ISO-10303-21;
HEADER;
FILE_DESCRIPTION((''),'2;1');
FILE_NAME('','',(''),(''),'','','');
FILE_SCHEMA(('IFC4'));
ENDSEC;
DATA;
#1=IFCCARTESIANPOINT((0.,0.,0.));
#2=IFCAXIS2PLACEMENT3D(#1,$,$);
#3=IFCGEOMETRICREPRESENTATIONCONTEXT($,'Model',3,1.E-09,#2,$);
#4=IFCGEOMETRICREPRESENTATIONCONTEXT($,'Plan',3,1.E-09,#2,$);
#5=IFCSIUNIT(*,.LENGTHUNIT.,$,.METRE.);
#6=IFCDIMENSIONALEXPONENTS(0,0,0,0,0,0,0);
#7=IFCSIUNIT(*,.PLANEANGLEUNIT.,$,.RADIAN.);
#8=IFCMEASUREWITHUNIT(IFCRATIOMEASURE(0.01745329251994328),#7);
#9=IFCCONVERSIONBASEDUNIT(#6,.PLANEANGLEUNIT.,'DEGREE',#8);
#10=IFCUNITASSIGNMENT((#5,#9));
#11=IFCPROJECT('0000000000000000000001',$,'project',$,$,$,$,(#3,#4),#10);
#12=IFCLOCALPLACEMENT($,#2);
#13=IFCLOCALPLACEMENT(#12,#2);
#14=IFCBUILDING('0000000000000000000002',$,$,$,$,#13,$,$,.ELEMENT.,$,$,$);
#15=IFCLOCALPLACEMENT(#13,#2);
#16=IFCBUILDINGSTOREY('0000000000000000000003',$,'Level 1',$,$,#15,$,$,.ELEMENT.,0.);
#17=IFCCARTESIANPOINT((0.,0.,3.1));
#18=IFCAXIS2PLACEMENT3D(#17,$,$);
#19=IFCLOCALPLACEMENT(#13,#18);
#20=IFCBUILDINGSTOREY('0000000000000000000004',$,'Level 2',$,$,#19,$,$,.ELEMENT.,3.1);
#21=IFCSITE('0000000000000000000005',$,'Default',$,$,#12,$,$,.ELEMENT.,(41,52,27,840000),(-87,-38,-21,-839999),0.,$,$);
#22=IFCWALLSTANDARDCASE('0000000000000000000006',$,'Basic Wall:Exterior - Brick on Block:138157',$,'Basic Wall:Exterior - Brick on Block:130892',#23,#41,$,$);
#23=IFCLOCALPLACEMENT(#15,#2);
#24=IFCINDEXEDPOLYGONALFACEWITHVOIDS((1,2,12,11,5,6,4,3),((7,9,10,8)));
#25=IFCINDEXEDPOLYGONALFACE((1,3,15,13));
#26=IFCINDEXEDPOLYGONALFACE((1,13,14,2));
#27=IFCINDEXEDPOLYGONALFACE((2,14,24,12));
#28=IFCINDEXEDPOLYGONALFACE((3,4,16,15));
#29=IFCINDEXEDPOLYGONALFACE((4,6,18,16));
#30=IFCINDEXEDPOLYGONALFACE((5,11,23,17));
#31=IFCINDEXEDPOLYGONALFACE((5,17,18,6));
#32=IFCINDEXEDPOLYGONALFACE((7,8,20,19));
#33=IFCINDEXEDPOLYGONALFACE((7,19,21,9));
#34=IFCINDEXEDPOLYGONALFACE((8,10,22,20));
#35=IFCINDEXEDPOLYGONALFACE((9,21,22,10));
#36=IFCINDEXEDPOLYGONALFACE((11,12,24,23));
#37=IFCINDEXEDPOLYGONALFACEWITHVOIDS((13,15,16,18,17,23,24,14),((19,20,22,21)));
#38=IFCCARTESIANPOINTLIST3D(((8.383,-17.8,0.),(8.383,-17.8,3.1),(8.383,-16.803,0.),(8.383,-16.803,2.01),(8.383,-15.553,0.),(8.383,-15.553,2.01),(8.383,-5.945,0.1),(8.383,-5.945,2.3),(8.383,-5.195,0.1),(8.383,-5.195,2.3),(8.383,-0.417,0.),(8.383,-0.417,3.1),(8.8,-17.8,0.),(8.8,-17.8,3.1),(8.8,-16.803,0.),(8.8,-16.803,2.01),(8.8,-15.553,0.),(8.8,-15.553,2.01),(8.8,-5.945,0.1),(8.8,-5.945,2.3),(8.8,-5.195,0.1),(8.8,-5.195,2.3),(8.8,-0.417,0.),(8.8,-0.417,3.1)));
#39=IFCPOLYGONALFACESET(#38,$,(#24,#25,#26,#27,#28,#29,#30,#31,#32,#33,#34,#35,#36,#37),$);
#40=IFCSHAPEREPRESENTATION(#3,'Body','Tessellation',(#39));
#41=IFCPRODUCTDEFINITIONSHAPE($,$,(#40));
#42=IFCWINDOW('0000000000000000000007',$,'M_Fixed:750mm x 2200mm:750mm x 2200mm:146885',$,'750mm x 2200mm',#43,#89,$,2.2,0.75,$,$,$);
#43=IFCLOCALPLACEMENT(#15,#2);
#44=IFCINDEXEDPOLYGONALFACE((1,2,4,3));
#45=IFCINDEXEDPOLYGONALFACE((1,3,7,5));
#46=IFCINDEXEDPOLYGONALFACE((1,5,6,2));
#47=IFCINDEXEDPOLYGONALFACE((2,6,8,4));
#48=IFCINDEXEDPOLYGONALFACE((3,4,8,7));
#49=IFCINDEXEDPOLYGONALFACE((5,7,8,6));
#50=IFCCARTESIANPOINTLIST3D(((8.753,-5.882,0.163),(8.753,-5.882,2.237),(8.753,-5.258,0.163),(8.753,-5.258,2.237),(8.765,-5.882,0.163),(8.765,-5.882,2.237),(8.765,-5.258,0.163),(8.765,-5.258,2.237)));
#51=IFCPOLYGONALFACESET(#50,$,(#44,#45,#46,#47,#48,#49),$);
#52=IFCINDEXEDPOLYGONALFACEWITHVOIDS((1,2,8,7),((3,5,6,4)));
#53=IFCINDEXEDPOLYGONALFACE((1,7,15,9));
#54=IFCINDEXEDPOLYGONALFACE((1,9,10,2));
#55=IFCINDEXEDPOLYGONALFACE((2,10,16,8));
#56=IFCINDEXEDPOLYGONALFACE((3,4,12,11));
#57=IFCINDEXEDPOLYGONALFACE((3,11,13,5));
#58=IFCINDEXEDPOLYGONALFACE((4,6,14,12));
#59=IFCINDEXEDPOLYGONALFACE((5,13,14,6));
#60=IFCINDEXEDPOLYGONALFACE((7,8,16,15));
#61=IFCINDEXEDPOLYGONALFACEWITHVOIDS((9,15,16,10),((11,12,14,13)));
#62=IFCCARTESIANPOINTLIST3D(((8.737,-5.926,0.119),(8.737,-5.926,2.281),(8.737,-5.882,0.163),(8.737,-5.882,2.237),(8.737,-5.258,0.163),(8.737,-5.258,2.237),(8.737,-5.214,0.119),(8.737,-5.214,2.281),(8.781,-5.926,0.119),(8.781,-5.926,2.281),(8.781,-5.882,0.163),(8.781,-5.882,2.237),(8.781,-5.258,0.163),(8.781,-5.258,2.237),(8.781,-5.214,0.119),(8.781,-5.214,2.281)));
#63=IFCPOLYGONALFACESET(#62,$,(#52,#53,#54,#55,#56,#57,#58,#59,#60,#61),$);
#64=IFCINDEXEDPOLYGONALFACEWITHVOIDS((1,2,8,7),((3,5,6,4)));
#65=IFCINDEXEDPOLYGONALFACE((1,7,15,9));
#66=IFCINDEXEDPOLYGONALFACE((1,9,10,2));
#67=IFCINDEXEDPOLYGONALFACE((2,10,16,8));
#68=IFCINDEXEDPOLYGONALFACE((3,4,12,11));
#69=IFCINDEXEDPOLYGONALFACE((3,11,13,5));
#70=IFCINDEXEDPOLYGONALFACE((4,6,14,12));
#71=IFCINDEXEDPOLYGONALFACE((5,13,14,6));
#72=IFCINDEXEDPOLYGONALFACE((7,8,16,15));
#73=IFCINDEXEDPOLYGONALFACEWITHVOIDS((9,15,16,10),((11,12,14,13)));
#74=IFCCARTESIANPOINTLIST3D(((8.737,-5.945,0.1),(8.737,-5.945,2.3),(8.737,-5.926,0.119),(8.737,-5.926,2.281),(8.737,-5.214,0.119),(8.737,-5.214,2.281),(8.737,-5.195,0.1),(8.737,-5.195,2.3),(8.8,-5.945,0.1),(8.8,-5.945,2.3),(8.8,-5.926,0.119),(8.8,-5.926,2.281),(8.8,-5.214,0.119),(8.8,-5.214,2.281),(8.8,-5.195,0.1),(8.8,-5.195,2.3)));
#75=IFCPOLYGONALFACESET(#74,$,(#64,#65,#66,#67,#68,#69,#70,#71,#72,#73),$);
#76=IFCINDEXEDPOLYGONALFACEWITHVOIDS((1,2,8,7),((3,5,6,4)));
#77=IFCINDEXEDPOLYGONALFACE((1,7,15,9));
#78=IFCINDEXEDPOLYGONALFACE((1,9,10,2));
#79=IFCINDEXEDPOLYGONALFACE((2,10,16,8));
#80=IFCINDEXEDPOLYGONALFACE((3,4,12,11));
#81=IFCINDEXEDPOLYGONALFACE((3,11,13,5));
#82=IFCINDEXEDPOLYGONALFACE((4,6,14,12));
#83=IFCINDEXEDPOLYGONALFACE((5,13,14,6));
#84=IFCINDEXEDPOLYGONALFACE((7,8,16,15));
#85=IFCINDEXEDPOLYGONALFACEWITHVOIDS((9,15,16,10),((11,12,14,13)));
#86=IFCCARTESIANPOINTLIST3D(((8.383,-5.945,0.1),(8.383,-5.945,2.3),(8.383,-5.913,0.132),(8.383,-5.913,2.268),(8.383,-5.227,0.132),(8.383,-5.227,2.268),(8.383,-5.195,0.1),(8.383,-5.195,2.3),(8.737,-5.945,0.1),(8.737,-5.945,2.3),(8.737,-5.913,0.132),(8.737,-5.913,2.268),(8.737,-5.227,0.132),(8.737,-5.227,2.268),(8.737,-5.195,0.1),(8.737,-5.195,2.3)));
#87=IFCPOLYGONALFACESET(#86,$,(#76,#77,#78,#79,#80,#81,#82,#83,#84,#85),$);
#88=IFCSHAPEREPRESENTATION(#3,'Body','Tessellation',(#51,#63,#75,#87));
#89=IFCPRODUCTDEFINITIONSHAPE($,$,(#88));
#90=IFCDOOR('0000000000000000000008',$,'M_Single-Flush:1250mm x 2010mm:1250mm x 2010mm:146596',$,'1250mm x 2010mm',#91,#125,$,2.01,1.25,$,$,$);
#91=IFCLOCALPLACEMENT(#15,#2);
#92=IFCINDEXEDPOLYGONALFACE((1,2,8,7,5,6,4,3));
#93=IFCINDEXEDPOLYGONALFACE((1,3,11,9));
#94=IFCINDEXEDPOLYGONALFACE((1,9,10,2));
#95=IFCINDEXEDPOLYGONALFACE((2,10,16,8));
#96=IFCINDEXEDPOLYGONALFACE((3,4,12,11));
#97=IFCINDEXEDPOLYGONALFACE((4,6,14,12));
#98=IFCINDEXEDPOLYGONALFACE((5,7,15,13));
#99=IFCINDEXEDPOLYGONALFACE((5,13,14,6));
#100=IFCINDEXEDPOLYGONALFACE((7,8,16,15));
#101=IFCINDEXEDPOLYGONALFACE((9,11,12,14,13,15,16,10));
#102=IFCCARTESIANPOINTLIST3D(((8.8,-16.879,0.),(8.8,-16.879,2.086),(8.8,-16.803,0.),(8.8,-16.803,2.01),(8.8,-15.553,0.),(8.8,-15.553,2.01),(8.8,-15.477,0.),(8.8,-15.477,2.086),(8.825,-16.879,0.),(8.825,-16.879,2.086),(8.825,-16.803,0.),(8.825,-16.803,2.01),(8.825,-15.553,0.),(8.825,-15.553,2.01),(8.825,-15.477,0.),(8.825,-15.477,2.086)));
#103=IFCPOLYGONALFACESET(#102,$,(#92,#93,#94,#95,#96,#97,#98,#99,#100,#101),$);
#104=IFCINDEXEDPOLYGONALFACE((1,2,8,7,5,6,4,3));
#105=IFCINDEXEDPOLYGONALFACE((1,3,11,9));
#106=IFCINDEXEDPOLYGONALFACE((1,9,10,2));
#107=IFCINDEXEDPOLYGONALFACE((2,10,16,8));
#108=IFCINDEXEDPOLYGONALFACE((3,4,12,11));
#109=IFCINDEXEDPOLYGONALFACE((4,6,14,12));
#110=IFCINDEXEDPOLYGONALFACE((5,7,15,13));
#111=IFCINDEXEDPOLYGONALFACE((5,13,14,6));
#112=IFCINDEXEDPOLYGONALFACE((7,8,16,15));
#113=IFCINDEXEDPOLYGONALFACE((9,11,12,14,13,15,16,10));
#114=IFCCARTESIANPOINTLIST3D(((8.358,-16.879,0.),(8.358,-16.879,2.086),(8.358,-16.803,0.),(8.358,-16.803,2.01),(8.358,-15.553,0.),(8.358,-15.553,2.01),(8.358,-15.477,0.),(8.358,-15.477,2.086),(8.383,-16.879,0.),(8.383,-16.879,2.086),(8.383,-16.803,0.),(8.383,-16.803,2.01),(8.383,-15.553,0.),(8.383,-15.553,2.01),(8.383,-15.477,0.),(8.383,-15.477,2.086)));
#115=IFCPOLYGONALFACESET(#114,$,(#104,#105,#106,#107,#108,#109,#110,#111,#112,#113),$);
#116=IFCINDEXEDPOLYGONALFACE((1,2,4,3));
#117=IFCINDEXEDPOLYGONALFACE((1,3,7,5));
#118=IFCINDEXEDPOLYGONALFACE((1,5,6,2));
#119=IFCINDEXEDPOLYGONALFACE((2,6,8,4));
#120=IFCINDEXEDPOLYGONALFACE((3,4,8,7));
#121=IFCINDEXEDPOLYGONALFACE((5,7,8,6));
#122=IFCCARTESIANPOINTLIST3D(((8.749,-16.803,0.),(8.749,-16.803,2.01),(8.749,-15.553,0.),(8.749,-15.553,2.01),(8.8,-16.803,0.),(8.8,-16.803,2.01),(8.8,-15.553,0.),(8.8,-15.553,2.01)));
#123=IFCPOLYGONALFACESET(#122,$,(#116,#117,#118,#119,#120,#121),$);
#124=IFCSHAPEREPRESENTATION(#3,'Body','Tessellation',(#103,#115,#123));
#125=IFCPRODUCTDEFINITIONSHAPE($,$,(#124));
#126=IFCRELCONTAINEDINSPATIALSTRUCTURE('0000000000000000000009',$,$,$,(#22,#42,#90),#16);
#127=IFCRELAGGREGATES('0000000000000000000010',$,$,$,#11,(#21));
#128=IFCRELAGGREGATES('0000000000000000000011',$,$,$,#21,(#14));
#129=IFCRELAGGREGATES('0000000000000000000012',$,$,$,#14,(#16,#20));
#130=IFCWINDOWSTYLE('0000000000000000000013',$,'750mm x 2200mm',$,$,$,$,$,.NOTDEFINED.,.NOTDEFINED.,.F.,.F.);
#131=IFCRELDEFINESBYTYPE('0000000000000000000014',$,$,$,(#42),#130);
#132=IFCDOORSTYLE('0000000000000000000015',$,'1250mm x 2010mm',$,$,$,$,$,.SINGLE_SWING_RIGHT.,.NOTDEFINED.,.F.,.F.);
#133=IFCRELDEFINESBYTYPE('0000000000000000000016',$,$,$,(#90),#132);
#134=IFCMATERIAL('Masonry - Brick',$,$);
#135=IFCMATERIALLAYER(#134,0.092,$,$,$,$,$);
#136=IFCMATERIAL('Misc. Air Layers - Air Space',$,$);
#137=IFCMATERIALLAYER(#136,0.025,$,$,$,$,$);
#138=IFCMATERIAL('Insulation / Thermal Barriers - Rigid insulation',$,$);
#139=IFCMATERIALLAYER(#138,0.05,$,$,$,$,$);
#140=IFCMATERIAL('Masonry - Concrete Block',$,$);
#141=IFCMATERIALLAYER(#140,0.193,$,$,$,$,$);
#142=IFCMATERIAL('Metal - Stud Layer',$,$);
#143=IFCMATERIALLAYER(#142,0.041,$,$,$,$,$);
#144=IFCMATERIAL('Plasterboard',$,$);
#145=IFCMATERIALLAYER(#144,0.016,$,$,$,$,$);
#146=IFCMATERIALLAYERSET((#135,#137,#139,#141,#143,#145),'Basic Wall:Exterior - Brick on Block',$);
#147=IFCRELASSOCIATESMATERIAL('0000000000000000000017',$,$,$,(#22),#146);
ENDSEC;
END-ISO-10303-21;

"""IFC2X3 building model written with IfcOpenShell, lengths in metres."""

from ifc_helpers import new_model, entity, si_unit, converted_unit, frame, frame_2d, origin, origin_2d_with_axis, place, context, project, spatial, polyline, rectangle, outline, extrude, source, transform, mapped, material, layer, layer_set, layer_usage, type_object, type_shapes, element, fill, save


model = new_model("IFC2X3")

# Units and contexts
model_context = context("Model", 3, precision=1e-09, world=origin())
plan_context = context("Plan", 3, precision=1e-09, world=origin())
ifc_project = project(units=[si_unit("LENGTHUNIT", "METRE"), converted_unit("PLANEANGLEUNIT", "DEGREE", entity("IfcRatioMeasure", 0.01745329251994328), si_unit("PLANEANGLEUNIT", "RADIAN"), dimensions=[0, 0, 0, 0, 0, 0, 0])], contexts=[model_context, plan_context])

# Site, building, storey
site_placement = place(None, origin())
site = spatial("IfcSite", under=ifc_project, at=site_placement, Name="Default", CompositionType="ELEMENT", RefLatitude=(41, 52, 27, 840000), RefLongitude=(-87, -38, -21, -839999), RefElevation=0.0)
building_placement = place(site_placement, origin())
building = spatial("IfcBuilding", under=site, at=building_placement, CompositionType="ELEMENT")
storey_1_placement = place(building_placement, origin())
storey_1 = spatial("IfcBuildingStorey", under=building, at=storey_1_placement, Name="Level 1", CompositionType="ELEMENT", Elevation=0.0)

# Wall, openings, window, door
ifc_material_1 = material(Name="Masonry - Brick")
ifc_layer_1 = layer(ifc_material_1, 0.092)
ifc_material_2 = material(Name="Misc. Air Layers - Air Space")
ifc_layer_2 = layer(ifc_material_2, 0.025)
ifc_material_3 = material(Name="Insulation / Thermal Barriers - Rigid insulation")
ifc_layer_3 = layer(ifc_material_3, 0.05)
ifc_material_4 = material(Name="Masonry - Concrete Block")
ifc_layer_4 = layer(ifc_material_4, 0.193)
ifc_material_5 = material(Name="Metal - Stud Layer")
ifc_layer_5 = layer(ifc_material_5, 0.041)
ifc_material_6 = material(Name="Plasterboard")
ifc_layer_6 = layer(ifc_material_6, 0.016)
ifc_layer_set_1 = layer_set([ifc_layer_1, ifc_layer_2, ifc_layer_3, ifc_layer_4, ifc_layer_5, ifc_layer_6], Name="Basic Wall:Exterior - Brick on Block")
ifc_layer_usage_1 = layer_usage(ifc_layer_set_1, "AXIS2", "NEGATIVE", 0.2085)
wall_1_placement = place(storey_1_placement, frame((8.5915, -0.417, 0.0), z_axis=(0.0, 0.0, 1.0), x_axis=(0.0, -1.0, 0.0)))
wall_1 = element("IfcWallStandardCase", 1, at=wall_1_placement, inside=storey_1, material=ifc_layer_usage_1, Name="Basic Wall:Exterior - Brick on Block:138157", ObjectType="Basic Wall:Exterior - Brick on Block:130892", context=model_context, shape_type="SweptSolid", body=[
    extrude(rectangle(XDim=17.383, YDim=0.417, at=frame_2d((8.6915, 0.0), x_axis=(-1.0, 0.0))), origin(), (0.0, 0.0, 1.0), 3.1),
])
opening_1_placement = place(wall_1_placement, frame((15.136, -0.2085, 0.0)))
opening_1 = element("IfcOpeningElement", 2, at=opening_1_placement, cuts=wall_1, ObjectType="Opening", context=model_context, shape_type="SweptSolid", body=[
    extrude(rectangle(XDim=1.25, YDim=2.01, at=frame_2d((1.005, 0.625), x_axis=(0.0, 1.0))), frame((0.0, 0.0, 0.0), z_axis=(0.0, 1.0, 0.0), x_axis=(0.0, 0.0, 1.0)), (0.0, 0.0, 1.0), 0.417),
])
opening_2_placement = place(wall_1_placement, frame((4.778, -0.2085, 0.1)))
opening_2 = element("IfcOpeningElement", 3, at=opening_2_placement, cuts=wall_1, ObjectType="Opening", context=model_context, shape_type="SweptSolid", body=[
    extrude(rectangle(XDim=2.2, YDim=0.75, at=frame_2d((1.1, 0.375), x_axis=(1.0, 0.0))), frame((0.0, 0.0, 0.0), z_axis=(0.0, 1.0, 0.0), x_axis=(0.0, 0.0, 1.0)), (0.0, 0.0, 1.0), 0.417),
])
window_style_1 = type_object("IfcWindowStyle", Name="750mm x 2200mm", ConstructionType="NOTDEFINED", OperationType="NOTDEFINED", ParameterTakesPrecedence=False, Sizeable=False)
shared_shape_1 = source(origin(), model_context, "Body", "SweptSolid", [
    extrude(rectangle(XDim=0.012, YDim=0.624, at=origin_2d_with_axis()), frame((0.375, 0.376, 0.063), z_axis=(0.0, 0.0, 1.0), x_axis=(0.0, -1.0, 0.0)), (0.0, 0.0, 1.0), 2.074),
    extrude(outline(polyline([(-0.356, -1.081), (0.356, -1.081), (0.356, 1.081), (-0.356, 1.081), (-0.356, -1.081)]), holes=[polyline([(-0.312, -1.037), (-0.312, 1.037), (0.312, 1.037), (0.312, -1.037), (-0.312, -1.037)])]), frame((0.375, 0.354, 1.1), z_axis=(0.0, 1.0, 0.0), x_axis=(1.0, 0.0, 0.0)), (0.0, 0.0, 1.0), 0.044),
    extrude(outline(polyline([(-0.375, -1.1), (0.375, -1.1), (0.375, 1.1), (-0.375, 1.1), (-0.375, -1.1)]), holes=[polyline([(-0.356, -1.081), (-0.356, 1.081), (0.356, 1.081), (0.356, -1.081), (-0.356, -1.081)])]), frame((0.375, 0.354, 1.1), z_axis=(0.0, 1.0, 0.0), x_axis=(1.0, 0.0, 0.0)), (0.0, 0.0, 1.0), 0.063),
    extrude(outline(polyline([(-0.375, -1.1), (0.375, -1.1), (0.375, 1.1), (-0.375, 1.1), (-0.375, -1.1)]), holes=[polyline([(-0.343, -1.068), (-0.343, 1.068), (0.343, 1.068), (0.343, -1.068), (-0.343, -1.068)])]), frame((0.375, 0.0, 1.1), z_axis=(0.0, 1.0, 0.0), x_axis=(1.0, 0.0, 0.0)), (0.0, 0.0, 1.0), 0.354),
])
type_shapes(window_style_1, [shared_shape_1])
window_1_placement = place(opening_2_placement, origin())
window_1 = element("IfcWindow", 4, at=window_1_placement, inside=storey_1, type_object=window_style_1, Name="M_Fixed:750mm x 2200mm:750mm x 2200mm:146885", ObjectType="750mm x 2200mm", OverallHeight=2.2, OverallWidth=0.75, context=model_context, shape_type="MappedRepresentation", body=[
    mapped(shared_shape_1, transform((0.0, 0.0, 0.0), scale=1.0)),
])
fill(opening_2, window_1)
door_style_1 = type_object("IfcDoorStyle", Name="1250mm x 2010mm", ConstructionType="NOTDEFINED", OperationType="SINGLE_SWING_RIGHT", ParameterTakesPrecedence=False, Sizeable=False)
shared_shape_2 = source(origin(), model_context, "Body", "SweptSolid", [
    extrude(outline(polyline([(-0.701, -1.062), (0.701, -1.062), (0.701, 1.024), (0.625, 1.024), (0.625, -0.986), (-0.625, -0.986), (-0.625, 1.024), (-0.701, 1.024), (-0.701, -1.062)])), frame((0.625, 0.417, 1.024), z_axis=(0.0, 1.0, 0.0), x_axis=(1.0, 0.0, 0.0)), (0.0, 0.0, 1.0), 0.025),
    extrude(outline(polyline([(-1.062, -0.701), (1.024, -0.701), (1.024, -0.625), (-0.986, -0.625), (-0.986, 0.625), (1.024, 0.625), (1.024, 0.701), (-1.062, 0.701), (-1.062, -0.701)])), frame((0.625, -0.025, 1.024), z_axis=(0.0, 1.0, 0.0), x_axis=(0.0, 0.0, -1.0)), (0.0, 0.0, 1.0), 0.025),
    extrude(rectangle(XDim=0.051, YDim=1.25, at=origin_2d_with_axis()), frame((0.625, 0.3915, 0.0), z_axis=(0.0, 0.0, 1.0), x_axis=(0.0, 1.0, 0.0)), (0.0, 0.0, 1.0), 2.01),
])
type_shapes(door_style_1, [shared_shape_2])
door_1_placement = place(opening_1_placement, origin())
door_1 = element("IfcDoor", 5, at=door_1_placement, inside=storey_1, type_object=door_style_1, Name="M_Single-Flush:1250mm x 2010mm:1250mm x 2010mm:146596", ObjectType="1250mm x 2010mm", OverallHeight=2.01, OverallWidth=1.25, context=model_context, shape_type="MappedRepresentation", body=[
    mapped(shared_shape_2, transform((0.0, 0.0, 0.0), scale=1.0)),
])
fill(opening_1, door_1)

# Shared definitions
storey_2_placement = place(building_placement, frame((0.0, 0.0, 3.1)))
storey_2 = spatial("IfcBuildingStorey", under=building, at=storey_2_placement, Name="Level 2", CompositionType="ELEMENT", Elevation=3.1)

save(model, "model.ifc")
